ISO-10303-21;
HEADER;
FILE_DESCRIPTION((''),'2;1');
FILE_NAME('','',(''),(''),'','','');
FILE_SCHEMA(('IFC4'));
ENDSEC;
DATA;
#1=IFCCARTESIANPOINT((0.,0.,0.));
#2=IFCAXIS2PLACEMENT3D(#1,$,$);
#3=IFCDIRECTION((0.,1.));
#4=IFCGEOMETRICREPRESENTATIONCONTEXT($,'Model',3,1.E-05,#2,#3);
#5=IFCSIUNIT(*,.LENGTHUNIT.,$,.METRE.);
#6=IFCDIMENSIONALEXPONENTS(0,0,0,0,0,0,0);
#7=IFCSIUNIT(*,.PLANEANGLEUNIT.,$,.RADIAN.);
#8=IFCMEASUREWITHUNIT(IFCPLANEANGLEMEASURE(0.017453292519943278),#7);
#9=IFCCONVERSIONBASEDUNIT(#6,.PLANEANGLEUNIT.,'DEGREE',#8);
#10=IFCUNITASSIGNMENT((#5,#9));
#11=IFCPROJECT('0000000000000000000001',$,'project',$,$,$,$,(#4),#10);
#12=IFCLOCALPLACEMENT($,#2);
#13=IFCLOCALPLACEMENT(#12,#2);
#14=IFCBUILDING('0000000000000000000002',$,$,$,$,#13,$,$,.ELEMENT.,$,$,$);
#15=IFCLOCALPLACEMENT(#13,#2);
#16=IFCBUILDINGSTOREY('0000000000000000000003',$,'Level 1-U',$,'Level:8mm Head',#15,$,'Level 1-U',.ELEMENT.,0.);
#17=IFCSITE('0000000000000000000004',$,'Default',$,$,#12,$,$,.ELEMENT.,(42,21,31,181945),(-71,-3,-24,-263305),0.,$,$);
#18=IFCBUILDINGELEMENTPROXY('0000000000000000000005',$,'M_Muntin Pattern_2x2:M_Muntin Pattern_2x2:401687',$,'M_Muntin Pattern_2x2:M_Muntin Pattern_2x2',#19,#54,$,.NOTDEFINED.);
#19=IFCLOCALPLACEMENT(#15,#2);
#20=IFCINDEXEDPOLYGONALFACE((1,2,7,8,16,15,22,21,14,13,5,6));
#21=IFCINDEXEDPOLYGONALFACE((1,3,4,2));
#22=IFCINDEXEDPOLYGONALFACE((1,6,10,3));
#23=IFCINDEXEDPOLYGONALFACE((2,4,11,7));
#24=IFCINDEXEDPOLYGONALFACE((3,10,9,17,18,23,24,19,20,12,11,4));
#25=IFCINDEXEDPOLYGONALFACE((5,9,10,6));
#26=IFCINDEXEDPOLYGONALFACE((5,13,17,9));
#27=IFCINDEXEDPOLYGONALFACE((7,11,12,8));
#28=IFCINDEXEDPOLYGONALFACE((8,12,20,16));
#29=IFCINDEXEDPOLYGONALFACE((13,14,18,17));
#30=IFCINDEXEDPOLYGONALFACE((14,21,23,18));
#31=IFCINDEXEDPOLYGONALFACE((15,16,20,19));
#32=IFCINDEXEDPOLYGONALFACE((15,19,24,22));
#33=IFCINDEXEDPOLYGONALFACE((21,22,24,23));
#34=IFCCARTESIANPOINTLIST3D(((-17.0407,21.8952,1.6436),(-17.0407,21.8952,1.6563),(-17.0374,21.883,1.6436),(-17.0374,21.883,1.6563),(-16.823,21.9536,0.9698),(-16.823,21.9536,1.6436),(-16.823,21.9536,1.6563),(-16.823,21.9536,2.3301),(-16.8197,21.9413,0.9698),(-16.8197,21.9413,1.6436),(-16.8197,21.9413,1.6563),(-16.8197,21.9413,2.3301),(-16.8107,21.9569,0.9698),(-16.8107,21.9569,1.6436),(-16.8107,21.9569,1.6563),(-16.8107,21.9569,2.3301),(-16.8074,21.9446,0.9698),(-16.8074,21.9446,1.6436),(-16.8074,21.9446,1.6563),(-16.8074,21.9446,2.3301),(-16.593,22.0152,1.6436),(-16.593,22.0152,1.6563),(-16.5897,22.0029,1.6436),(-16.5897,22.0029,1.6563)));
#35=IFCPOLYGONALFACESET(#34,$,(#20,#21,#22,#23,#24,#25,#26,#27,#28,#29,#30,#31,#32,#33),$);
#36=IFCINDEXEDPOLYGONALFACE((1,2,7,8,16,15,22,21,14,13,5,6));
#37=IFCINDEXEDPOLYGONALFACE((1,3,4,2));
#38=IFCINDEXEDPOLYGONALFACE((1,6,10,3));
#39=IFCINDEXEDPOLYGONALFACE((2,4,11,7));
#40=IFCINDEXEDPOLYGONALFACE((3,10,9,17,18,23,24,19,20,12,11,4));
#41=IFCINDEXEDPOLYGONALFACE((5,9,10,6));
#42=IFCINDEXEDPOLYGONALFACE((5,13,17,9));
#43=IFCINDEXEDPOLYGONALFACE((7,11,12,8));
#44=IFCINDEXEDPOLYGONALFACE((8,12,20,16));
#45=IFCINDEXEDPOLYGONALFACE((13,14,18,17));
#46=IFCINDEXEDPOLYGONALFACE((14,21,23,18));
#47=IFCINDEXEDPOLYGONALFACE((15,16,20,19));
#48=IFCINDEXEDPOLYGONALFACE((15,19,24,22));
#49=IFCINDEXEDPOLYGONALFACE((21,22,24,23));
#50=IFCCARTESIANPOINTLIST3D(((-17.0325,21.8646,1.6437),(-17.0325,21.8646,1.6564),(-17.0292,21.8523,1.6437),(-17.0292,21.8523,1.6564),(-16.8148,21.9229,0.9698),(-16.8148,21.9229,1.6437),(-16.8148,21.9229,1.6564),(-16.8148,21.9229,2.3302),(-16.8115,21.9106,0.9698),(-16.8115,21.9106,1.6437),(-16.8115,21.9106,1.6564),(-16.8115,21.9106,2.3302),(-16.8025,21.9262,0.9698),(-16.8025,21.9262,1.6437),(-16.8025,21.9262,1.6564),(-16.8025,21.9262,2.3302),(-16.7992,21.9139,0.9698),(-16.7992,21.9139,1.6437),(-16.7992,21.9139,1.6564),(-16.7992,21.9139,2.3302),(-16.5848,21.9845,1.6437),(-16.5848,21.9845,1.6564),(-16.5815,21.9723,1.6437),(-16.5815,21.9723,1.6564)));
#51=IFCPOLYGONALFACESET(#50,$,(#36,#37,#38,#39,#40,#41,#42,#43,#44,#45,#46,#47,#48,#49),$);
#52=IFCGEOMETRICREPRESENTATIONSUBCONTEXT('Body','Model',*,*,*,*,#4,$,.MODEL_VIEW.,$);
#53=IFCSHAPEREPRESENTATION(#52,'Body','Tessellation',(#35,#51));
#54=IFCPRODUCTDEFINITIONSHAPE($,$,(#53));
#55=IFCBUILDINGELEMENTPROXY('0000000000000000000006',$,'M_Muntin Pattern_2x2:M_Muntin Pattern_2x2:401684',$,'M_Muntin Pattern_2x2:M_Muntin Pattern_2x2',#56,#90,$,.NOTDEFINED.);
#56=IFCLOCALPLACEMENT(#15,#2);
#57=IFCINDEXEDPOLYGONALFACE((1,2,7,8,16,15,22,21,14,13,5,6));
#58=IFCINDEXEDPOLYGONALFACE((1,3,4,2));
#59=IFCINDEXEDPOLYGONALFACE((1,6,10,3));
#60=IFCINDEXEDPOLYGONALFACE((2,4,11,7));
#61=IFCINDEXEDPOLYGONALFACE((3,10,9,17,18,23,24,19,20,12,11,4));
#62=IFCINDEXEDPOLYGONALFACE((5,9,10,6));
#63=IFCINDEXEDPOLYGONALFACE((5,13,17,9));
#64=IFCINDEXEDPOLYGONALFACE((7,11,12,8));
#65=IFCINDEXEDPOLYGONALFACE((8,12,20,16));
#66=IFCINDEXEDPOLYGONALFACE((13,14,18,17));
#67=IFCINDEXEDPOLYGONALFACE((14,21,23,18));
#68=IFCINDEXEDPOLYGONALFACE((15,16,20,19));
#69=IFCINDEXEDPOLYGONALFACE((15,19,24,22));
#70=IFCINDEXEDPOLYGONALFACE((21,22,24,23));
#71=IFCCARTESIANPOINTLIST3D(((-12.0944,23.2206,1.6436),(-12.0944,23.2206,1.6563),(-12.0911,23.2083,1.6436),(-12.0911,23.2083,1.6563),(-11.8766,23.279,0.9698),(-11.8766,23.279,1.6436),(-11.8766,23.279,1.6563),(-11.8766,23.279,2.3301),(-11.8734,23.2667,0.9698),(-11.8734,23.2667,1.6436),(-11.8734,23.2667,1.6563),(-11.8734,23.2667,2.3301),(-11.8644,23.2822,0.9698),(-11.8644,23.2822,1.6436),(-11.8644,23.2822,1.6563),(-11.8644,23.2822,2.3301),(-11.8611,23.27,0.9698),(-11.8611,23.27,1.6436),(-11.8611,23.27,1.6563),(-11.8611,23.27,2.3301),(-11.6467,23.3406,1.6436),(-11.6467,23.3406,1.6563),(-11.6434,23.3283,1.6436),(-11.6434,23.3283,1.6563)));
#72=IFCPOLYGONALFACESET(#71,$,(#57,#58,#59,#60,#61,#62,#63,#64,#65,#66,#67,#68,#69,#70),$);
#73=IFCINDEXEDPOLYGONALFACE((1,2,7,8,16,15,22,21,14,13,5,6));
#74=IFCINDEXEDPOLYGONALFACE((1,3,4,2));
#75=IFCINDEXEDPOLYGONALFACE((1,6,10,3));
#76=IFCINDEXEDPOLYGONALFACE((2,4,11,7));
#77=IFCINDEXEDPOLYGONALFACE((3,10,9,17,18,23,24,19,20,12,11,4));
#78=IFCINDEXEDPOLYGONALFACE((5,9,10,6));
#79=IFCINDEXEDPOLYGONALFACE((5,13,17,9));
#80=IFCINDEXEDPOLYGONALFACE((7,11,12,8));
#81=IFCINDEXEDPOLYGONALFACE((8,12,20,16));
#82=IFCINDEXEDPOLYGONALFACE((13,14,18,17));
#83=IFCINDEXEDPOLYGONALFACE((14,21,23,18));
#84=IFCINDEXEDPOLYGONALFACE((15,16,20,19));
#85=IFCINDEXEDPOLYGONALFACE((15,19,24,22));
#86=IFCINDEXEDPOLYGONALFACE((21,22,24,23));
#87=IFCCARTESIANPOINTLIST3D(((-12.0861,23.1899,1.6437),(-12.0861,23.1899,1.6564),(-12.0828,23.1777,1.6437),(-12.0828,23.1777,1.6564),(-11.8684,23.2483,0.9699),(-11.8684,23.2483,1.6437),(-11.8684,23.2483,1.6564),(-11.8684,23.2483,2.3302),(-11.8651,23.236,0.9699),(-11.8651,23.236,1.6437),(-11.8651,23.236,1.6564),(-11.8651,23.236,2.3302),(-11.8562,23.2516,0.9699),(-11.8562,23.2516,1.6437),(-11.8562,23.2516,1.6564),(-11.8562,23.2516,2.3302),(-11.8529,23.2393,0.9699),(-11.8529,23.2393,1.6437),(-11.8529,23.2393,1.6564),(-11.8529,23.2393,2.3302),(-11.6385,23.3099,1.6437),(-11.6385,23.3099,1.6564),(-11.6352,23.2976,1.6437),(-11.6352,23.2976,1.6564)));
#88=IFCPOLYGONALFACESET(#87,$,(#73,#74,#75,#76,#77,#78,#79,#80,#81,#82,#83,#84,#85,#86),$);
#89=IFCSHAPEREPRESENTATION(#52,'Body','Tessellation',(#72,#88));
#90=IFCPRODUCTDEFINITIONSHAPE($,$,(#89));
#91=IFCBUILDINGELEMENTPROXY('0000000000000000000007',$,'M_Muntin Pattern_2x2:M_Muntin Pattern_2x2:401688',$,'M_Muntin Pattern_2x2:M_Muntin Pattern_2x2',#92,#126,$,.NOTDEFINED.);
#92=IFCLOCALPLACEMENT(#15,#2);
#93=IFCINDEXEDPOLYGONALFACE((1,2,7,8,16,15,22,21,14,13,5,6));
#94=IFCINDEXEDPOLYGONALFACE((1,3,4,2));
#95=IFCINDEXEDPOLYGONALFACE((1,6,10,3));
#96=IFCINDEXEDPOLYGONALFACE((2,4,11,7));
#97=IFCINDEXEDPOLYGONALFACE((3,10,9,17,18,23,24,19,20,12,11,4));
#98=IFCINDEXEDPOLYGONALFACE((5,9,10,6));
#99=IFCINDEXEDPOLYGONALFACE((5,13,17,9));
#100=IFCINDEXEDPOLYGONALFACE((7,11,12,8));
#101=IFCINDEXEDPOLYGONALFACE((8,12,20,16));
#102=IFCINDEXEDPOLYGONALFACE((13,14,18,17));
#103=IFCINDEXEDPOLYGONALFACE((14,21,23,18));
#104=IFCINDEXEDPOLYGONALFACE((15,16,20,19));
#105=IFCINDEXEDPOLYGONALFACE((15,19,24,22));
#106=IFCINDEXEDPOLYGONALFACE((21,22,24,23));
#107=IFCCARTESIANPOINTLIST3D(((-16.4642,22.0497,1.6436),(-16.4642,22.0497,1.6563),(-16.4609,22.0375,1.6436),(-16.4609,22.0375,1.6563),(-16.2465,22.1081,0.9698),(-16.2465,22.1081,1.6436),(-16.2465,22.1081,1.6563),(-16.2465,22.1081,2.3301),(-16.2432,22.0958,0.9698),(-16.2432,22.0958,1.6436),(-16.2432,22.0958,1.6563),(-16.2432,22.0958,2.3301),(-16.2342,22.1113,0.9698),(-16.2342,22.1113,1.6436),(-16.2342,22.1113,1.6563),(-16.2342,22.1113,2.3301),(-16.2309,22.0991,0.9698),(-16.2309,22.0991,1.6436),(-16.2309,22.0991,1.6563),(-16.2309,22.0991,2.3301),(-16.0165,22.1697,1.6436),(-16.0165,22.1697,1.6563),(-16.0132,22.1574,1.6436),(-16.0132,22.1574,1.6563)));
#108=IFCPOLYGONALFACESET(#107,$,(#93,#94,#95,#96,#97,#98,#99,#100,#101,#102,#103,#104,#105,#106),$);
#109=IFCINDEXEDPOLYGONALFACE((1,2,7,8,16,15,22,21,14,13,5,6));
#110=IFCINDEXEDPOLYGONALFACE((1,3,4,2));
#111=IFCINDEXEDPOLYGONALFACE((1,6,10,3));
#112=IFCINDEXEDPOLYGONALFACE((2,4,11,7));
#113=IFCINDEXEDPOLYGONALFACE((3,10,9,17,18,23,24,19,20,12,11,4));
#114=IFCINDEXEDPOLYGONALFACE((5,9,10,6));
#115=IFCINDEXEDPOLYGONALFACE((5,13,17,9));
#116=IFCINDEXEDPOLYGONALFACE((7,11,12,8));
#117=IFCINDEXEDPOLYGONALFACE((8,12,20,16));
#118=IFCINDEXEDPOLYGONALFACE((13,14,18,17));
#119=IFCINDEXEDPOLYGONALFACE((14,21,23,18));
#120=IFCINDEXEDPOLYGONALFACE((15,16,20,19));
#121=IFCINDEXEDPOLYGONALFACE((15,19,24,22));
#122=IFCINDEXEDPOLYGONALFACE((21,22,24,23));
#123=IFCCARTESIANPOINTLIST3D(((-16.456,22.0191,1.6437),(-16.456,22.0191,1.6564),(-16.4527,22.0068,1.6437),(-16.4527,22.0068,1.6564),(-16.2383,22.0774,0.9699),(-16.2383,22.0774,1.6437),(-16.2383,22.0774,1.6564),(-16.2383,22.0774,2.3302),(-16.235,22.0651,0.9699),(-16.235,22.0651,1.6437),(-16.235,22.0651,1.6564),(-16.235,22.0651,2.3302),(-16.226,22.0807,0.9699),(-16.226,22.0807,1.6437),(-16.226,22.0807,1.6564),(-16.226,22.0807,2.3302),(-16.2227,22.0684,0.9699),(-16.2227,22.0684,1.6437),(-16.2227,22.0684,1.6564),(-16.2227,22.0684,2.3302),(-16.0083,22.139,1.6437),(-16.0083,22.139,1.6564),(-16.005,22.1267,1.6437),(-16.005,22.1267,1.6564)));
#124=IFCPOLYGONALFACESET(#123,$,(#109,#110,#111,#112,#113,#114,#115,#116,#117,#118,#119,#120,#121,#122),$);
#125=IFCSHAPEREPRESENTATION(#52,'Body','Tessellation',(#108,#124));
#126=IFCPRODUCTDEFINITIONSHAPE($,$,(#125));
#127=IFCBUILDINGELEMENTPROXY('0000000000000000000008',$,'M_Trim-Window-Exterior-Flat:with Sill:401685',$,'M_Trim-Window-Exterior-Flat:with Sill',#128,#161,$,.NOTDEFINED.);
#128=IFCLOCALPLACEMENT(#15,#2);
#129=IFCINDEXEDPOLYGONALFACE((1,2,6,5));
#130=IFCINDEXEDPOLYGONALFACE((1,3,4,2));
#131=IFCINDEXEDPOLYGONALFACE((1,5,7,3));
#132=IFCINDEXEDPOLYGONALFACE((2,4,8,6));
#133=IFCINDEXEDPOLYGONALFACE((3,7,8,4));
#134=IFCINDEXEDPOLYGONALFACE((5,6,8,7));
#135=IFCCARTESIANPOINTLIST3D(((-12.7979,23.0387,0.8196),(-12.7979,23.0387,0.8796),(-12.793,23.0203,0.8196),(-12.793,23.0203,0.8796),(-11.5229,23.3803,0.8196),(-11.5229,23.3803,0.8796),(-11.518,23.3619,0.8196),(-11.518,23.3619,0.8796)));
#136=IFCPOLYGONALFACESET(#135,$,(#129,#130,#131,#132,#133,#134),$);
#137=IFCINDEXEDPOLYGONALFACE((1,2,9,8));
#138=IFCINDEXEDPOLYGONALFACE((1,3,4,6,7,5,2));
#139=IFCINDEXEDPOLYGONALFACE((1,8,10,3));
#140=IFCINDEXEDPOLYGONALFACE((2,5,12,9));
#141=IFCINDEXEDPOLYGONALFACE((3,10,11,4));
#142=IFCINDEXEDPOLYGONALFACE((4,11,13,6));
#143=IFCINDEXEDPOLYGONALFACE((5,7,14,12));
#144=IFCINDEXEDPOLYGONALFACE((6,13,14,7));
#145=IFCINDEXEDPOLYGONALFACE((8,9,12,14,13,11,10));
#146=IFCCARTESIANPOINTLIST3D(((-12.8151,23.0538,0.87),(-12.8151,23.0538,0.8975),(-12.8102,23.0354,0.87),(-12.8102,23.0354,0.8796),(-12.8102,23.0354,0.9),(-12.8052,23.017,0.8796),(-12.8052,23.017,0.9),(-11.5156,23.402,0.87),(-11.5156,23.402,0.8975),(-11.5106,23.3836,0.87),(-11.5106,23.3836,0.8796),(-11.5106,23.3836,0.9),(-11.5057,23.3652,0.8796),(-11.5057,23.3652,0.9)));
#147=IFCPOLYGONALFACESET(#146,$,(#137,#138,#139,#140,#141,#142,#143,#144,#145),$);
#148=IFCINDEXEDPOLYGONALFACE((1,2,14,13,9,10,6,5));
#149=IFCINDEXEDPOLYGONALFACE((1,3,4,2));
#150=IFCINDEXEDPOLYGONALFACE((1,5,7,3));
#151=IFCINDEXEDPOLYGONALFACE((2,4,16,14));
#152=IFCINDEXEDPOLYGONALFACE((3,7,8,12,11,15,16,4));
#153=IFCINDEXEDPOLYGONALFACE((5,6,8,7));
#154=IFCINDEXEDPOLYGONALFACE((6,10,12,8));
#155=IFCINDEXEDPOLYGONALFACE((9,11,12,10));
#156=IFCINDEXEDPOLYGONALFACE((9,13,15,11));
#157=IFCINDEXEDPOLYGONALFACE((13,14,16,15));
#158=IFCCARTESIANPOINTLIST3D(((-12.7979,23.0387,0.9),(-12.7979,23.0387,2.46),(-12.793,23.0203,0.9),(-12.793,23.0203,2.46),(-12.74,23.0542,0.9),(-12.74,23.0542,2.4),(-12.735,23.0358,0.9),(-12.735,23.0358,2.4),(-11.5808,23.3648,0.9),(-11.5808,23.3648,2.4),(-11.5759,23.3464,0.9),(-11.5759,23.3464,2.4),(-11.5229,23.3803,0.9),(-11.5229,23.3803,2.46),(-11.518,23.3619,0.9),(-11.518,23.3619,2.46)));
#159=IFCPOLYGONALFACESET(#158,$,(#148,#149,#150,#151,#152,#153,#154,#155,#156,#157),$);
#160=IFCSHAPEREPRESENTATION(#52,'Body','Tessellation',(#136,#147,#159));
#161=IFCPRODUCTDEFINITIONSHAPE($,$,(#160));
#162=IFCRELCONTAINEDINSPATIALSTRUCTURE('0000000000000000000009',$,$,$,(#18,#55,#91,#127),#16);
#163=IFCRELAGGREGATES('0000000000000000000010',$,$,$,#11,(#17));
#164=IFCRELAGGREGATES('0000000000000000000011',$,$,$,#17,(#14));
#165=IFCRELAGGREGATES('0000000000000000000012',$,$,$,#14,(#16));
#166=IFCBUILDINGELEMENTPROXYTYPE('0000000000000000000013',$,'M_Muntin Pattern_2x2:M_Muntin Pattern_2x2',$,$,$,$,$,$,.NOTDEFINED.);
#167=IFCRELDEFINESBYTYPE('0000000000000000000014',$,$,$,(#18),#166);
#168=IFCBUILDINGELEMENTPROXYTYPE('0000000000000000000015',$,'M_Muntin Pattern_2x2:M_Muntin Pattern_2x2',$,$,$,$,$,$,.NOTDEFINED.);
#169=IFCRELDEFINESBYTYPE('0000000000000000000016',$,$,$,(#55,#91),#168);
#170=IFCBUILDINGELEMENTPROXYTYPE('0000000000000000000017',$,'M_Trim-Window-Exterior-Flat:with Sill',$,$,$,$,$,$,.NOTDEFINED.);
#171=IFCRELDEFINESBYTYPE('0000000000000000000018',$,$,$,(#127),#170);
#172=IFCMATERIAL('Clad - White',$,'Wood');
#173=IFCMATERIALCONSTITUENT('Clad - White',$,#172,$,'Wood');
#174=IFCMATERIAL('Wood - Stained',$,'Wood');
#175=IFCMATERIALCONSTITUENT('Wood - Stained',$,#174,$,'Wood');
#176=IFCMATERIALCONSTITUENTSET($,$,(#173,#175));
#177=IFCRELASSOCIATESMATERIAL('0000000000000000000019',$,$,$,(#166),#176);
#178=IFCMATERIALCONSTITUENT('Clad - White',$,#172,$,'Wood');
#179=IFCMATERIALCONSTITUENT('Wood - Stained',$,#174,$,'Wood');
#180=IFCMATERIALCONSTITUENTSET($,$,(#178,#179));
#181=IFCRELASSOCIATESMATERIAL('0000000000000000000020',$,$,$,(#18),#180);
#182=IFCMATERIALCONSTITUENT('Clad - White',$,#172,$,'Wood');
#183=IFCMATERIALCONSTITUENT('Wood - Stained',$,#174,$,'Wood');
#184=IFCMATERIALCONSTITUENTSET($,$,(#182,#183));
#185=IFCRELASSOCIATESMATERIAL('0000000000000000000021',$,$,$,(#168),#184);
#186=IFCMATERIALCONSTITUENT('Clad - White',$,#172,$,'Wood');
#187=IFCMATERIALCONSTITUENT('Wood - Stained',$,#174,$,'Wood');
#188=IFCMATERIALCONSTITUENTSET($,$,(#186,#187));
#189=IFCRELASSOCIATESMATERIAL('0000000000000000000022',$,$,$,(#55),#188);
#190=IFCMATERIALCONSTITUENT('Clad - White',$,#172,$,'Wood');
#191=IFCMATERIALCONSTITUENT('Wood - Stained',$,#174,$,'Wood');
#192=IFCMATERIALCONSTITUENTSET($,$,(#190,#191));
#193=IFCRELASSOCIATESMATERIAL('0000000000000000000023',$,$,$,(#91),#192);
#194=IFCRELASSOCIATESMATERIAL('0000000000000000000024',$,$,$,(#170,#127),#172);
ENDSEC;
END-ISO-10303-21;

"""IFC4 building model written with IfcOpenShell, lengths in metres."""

from ifc_helpers import new_model, entity, si_unit, converted_unit, direction, frame, frame_2d, origin, place, context, subcontext, project, spatial, polyline, rectangle, outline, extrude, source, transform, mapped, material, constituent, constituent_set, type_object, type_shapes, element, save


model = new_model("IFC4")

# Units and contexts
model_context = context("Model", 3, precision=1e-05, world=origin(), true_north=direction((0.0, 1.0)))
body_context = subcontext(model_context, "Body", "Model", "MODEL_VIEW")
ifc_project = project(units=[si_unit("LENGTHUNIT", "METRE"), converted_unit("PLANEANGLEUNIT", "DEGREE", entity("IfcPlaneAngleMeasure", 0.017453292519943278), si_unit("PLANEANGLEUNIT", "RADIAN"), dimensions=[0, 0, 0, 0, 0, 0, 0])], contexts=[model_context])

# Site, building, storey
site_placement = place(None, origin())
site = spatial("IfcSite", under=ifc_project, at=site_placement, Name="Default", CompositionType="ELEMENT", RefLatitude=(42, 21, 31, 181945), RefLongitude=(-71, -3, -24, -263305), RefElevation=0.0)
building_placement = place(site_placement, origin())
building = spatial("IfcBuilding", under=site, at=building_placement, CompositionType="ELEMENT")
storey_placement = place(building_placement, origin())
storey = spatial("IfcBuildingStorey", under=building, at=storey_placement, Name="Level 1-U", ObjectType="Level:8mm Head", LongName="Level 1-U", CompositionType="ELEMENT", Elevation=0.0)

# Building element proxies
ifc_material_1 = material(Name="Clad - White", Category="Wood")
ifc_material_2 = material(Name="Wood - Stained", Category="Wood")
ifc_constituent_1 = constituent(ifc_material_1, Name="Clad - White", Category="Wood")
ifc_constituent_2 = constituent(ifc_material_2, Name="Wood - Stained", Category="Wood")
ifc_constituent_set_1 = constituent_set(constituents=[ifc_constituent_1, ifc_constituent_2])
building_element_proxy_type_1 = type_object("IfcBuildingElementProxyType", Name="M_Muntin Pattern_2x2:M_Muntin Pattern_2x2", PredefinedType="NOTDEFINED", material=ifc_constituent_set_1)
shared_shape_1 = source(origin(), body_context, "Body", "SweptSolid", [
    extrude(outline(polyline([(0.0064, -0.0064), (0.6801, -0.0064), (0.6801, 0.0063), (0.0064, 0.0063), (0.0064, 0.2317), (-0.0063, 0.2317), (-0.0063, 0.0063), (-0.6802, 0.0063), (-0.6802, -0.0064), (-0.0063, -0.0064), (-0.0063, -0.2317), (0.0064, -0.2317), (0.0064, -0.0064)])), frame((0.0, 0.0095, 0.6801), z_axis=(0.0, 1.0, 0.0), x_axis=(0.0, 0.0, 1.0)), (0.0, 0.0, 1.0), 0.0127),
    extrude(outline(polyline([(0.0064, -0.0064), (0.6802, -0.0064), (0.6802, 0.0063), (0.0064, 0.0063), (0.0064, 0.2317), (-0.0063, 0.2317), (-0.0063, 0.0063), (-0.6802, 0.0063), (-0.6802, -0.0064), (-0.0063, -0.0064), (-0.0063, -0.2317), (0.0064, -0.2317), (0.0064, -0.0064)])), frame((0.0, -0.0222, 0.6802), z_axis=(0.0, 1.0, 0.0), x_axis=(0.0, 0.0, 1.0)), (0.0, 0.0, 1.0), 0.0127),
])
type_shapes(building_element_proxy_type_1, [shared_shape_1])
ifc_constituent_3 = constituent(ifc_material_1, Name="Clad - White", Category="Wood")
ifc_constituent_4 = constituent(ifc_material_2, Name="Wood - Stained", Category="Wood")
ifc_constituent_set_2 = constituent_set(constituents=[ifc_constituent_3, ifc_constituent_4])
proxy_1_placement = place(storey_placement, frame((-16.8111, 21.9338, 0.9698), z_axis=(0.0, 0.0, 1.0), x_axis=(0.965926, 0.258819, 0.0)))
element("IfcBuildingElementProxy", 1, at=proxy_1_placement, inside=storey, type_object=building_element_proxy_type_1, material=ifc_constituent_set_2, Name="M_Muntin Pattern_2x2:M_Muntin Pattern_2x2:401687", ObjectType="M_Muntin Pattern_2x2:M_Muntin Pattern_2x2", PredefinedType="NOTDEFINED", context=body_context, shape_type="MappedRepresentation", body=[
    mapped(shared_shape_1, transform((0.0, 0.0, 0.0), scale=1.0)),
])
ifc_constituent_5 = constituent(ifc_material_1, Name="Clad - White", Category="Wood")
ifc_constituent_6 = constituent(ifc_material_2, Name="Wood - Stained", Category="Wood")
ifc_constituent_set_3 = constituent_set(constituents=[ifc_constituent_5, ifc_constituent_6])
ifc_constituent_7 = constituent(ifc_material_1, Name="Clad - White", Category="Wood")
ifc_constituent_8 = constituent(ifc_material_2, Name="Wood - Stained", Category="Wood")
ifc_constituent_set_4 = constituent_set(constituents=[ifc_constituent_7, ifc_constituent_8])
building_element_proxy_type_2 = type_object("IfcBuildingElementProxyType", Name="M_Muntin Pattern_2x2:M_Muntin Pattern_2x2", PredefinedType="NOTDEFINED", material=ifc_constituent_set_4)
shared_shape_2 = source(origin(), body_context, "Body", "SweptSolid", [
    extrude(outline(polyline([(0.0064, -0.0064), (0.6801, -0.0064), (0.6801, 0.0063), (0.0064, 0.0063), (0.0064, 0.2317), (-0.0063, 0.2317), (-0.0063, 0.0063), (-0.6802, 0.0063), (-0.6802, -0.0064), (-0.0063, -0.0064), (-0.0063, -0.2317), (0.0064, -0.2317), (0.0064, -0.0064)])), frame((0.0, -0.0222, 0.6801), z_axis=(0.0, 1.0, 0.0), x_axis=(0.0, 0.0, 1.0)), (0.0, 0.0, 1.0), 0.0127),
    extrude(outline(polyline([(0.0064, -0.0064), (0.6802, -0.0064), (0.6802, 0.0063), (0.0064, 0.0063), (0.0064, 0.2317), (-0.0063, 0.2317), (-0.0063, 0.0063), (-0.6802, 0.0063), (-0.6802, -0.0064), (-0.0063, -0.0064), (-0.0063, -0.2317), (0.0064, -0.2317), (0.0064, -0.0064)])), frame((0.0, 0.0095, 0.6802), z_axis=(0.0, 1.0, 0.0), x_axis=(0.0, 0.0, 1.0)), (0.0, 0.0, 1.0), 0.0127),
])
type_shapes(building_element_proxy_type_2, [shared_shape_2])
proxy_2_placement = place(storey_placement, frame((-11.8648, 23.2591, 0.9699), z_axis=(0.0, 0.0, 1.0), x_axis=(-0.965926, -0.258819, 0.0)))
element("IfcBuildingElementProxy", 2, at=proxy_2_placement, inside=storey, type_object=building_element_proxy_type_2, material=ifc_constituent_set_3, Name="M_Muntin Pattern_2x2:M_Muntin Pattern_2x2:401684", ObjectType="M_Muntin Pattern_2x2:M_Muntin Pattern_2x2", PredefinedType="NOTDEFINED", context=body_context, shape_type="MappedRepresentation", body=[
    mapped(shared_shape_2, transform((0.0, 0.0, 0.0), scale=1.0)),
])
ifc_constituent_9 = constituent(ifc_material_1, Name="Clad - White", Category="Wood")
ifc_constituent_10 = constituent(ifc_material_2, Name="Wood - Stained", Category="Wood")
ifc_constituent_set_5 = constituent_set(constituents=[ifc_constituent_9, ifc_constituent_10])
proxy_3_placement = place(storey_placement, frame((-16.2346, 22.0882, 0.9699), z_axis=(0.0, 0.0, 1.0), x_axis=(-0.965926, -0.258819, 0.0)))
element("IfcBuildingElementProxy", 3, at=proxy_3_placement, inside=storey, type_object=building_element_proxy_type_2, material=ifc_constituent_set_5, Name="M_Muntin Pattern_2x2:M_Muntin Pattern_2x2:401688", ObjectType="M_Muntin Pattern_2x2:M_Muntin Pattern_2x2", PredefinedType="NOTDEFINED", context=body_context, shape_type="MappedRepresentation", body=[
    mapped(shared_shape_2, transform((0.0, 0.0, 0.0), scale=1.0)),
])
building_element_proxy_type_3 = type_object("IfcBuildingElementProxyType", Name="M_Trim-Window-Exterior-Flat:with Sill", PredefinedType="NOTDEFINED", material=ifc_material_1)
shared_shape_3 = source(origin(), body_context, "Body", "SweptSolid", [
    extrude(rectangle(XDim=1.32, YDim=0.06, at=frame_2d((0.0, 0.0), x_axis=(1.0, 0.0))), frame((0.0, -1.5504, 0.0), z_axis=(0.0, 0.0, 1.0), x_axis=(-1.0, 0.0, 0.0)), (0.0, 0.0, 1.0), 0.019),
    extrude(outline(polyline([(-0.019, -0.0152), (0.0, -0.0152), (0.0, -0.0057), (0.019, -0.0057), (0.019, 0.0148), (0.0, 0.0148), (-0.019, 0.0123), (-0.019, -0.0152)])), frame((-0.6727, -1.5148, 0.019), z_axis=(1.0, 0.0, 0.0), x_axis=(0.0, 0.0, -1.0)), (0.0, 0.0, 1.0), 1.3454),
    extrude(outline(polyline([(-0.795, -0.66), (0.765, -0.66), (0.765, -0.6), (-0.735, -0.6), (-0.735, 0.6), (0.765, 0.6), (0.765, 0.66), (-0.795, 0.66), (-0.795, -0.66)])), frame((0.0, -0.735, 0.0), z_axis=(0.0, 0.0, 1.0), x_axis=(0.0, -1.0, 0.0)), (0.0, 0.0, 1.0), 0.019),
])
type_shapes(building_element_proxy_type_3, [shared_shape_3])
for number, where, z_axis, x_axis, name in (
    (4, (-12.1555, 23.1911, 2.4), (-0.258819, 0.965926, 0.0), (-0.965926, -0.258819, 0.0), "M_Trim-Window-Exterior-Flat:with Sill:401685"),
):
    element("IfcBuildingElementProxy", number, at=place(storey_placement, frame(where, z_axis=z_axis, x_axis=x_axis)), inside=storey, type_object=building_element_proxy_type_3, material=ifc_material_1, Name=name, ObjectType="M_Trim-Window-Exterior-Flat:with Sill", PredefinedType="NOTDEFINED", context=body_context, shape_type="MappedRepresentation", body=[
        mapped(shared_shape_3, transform((0.0, 0.0, 0.0), scale=1.0)),
    ])

save(model, "model.ifc")
